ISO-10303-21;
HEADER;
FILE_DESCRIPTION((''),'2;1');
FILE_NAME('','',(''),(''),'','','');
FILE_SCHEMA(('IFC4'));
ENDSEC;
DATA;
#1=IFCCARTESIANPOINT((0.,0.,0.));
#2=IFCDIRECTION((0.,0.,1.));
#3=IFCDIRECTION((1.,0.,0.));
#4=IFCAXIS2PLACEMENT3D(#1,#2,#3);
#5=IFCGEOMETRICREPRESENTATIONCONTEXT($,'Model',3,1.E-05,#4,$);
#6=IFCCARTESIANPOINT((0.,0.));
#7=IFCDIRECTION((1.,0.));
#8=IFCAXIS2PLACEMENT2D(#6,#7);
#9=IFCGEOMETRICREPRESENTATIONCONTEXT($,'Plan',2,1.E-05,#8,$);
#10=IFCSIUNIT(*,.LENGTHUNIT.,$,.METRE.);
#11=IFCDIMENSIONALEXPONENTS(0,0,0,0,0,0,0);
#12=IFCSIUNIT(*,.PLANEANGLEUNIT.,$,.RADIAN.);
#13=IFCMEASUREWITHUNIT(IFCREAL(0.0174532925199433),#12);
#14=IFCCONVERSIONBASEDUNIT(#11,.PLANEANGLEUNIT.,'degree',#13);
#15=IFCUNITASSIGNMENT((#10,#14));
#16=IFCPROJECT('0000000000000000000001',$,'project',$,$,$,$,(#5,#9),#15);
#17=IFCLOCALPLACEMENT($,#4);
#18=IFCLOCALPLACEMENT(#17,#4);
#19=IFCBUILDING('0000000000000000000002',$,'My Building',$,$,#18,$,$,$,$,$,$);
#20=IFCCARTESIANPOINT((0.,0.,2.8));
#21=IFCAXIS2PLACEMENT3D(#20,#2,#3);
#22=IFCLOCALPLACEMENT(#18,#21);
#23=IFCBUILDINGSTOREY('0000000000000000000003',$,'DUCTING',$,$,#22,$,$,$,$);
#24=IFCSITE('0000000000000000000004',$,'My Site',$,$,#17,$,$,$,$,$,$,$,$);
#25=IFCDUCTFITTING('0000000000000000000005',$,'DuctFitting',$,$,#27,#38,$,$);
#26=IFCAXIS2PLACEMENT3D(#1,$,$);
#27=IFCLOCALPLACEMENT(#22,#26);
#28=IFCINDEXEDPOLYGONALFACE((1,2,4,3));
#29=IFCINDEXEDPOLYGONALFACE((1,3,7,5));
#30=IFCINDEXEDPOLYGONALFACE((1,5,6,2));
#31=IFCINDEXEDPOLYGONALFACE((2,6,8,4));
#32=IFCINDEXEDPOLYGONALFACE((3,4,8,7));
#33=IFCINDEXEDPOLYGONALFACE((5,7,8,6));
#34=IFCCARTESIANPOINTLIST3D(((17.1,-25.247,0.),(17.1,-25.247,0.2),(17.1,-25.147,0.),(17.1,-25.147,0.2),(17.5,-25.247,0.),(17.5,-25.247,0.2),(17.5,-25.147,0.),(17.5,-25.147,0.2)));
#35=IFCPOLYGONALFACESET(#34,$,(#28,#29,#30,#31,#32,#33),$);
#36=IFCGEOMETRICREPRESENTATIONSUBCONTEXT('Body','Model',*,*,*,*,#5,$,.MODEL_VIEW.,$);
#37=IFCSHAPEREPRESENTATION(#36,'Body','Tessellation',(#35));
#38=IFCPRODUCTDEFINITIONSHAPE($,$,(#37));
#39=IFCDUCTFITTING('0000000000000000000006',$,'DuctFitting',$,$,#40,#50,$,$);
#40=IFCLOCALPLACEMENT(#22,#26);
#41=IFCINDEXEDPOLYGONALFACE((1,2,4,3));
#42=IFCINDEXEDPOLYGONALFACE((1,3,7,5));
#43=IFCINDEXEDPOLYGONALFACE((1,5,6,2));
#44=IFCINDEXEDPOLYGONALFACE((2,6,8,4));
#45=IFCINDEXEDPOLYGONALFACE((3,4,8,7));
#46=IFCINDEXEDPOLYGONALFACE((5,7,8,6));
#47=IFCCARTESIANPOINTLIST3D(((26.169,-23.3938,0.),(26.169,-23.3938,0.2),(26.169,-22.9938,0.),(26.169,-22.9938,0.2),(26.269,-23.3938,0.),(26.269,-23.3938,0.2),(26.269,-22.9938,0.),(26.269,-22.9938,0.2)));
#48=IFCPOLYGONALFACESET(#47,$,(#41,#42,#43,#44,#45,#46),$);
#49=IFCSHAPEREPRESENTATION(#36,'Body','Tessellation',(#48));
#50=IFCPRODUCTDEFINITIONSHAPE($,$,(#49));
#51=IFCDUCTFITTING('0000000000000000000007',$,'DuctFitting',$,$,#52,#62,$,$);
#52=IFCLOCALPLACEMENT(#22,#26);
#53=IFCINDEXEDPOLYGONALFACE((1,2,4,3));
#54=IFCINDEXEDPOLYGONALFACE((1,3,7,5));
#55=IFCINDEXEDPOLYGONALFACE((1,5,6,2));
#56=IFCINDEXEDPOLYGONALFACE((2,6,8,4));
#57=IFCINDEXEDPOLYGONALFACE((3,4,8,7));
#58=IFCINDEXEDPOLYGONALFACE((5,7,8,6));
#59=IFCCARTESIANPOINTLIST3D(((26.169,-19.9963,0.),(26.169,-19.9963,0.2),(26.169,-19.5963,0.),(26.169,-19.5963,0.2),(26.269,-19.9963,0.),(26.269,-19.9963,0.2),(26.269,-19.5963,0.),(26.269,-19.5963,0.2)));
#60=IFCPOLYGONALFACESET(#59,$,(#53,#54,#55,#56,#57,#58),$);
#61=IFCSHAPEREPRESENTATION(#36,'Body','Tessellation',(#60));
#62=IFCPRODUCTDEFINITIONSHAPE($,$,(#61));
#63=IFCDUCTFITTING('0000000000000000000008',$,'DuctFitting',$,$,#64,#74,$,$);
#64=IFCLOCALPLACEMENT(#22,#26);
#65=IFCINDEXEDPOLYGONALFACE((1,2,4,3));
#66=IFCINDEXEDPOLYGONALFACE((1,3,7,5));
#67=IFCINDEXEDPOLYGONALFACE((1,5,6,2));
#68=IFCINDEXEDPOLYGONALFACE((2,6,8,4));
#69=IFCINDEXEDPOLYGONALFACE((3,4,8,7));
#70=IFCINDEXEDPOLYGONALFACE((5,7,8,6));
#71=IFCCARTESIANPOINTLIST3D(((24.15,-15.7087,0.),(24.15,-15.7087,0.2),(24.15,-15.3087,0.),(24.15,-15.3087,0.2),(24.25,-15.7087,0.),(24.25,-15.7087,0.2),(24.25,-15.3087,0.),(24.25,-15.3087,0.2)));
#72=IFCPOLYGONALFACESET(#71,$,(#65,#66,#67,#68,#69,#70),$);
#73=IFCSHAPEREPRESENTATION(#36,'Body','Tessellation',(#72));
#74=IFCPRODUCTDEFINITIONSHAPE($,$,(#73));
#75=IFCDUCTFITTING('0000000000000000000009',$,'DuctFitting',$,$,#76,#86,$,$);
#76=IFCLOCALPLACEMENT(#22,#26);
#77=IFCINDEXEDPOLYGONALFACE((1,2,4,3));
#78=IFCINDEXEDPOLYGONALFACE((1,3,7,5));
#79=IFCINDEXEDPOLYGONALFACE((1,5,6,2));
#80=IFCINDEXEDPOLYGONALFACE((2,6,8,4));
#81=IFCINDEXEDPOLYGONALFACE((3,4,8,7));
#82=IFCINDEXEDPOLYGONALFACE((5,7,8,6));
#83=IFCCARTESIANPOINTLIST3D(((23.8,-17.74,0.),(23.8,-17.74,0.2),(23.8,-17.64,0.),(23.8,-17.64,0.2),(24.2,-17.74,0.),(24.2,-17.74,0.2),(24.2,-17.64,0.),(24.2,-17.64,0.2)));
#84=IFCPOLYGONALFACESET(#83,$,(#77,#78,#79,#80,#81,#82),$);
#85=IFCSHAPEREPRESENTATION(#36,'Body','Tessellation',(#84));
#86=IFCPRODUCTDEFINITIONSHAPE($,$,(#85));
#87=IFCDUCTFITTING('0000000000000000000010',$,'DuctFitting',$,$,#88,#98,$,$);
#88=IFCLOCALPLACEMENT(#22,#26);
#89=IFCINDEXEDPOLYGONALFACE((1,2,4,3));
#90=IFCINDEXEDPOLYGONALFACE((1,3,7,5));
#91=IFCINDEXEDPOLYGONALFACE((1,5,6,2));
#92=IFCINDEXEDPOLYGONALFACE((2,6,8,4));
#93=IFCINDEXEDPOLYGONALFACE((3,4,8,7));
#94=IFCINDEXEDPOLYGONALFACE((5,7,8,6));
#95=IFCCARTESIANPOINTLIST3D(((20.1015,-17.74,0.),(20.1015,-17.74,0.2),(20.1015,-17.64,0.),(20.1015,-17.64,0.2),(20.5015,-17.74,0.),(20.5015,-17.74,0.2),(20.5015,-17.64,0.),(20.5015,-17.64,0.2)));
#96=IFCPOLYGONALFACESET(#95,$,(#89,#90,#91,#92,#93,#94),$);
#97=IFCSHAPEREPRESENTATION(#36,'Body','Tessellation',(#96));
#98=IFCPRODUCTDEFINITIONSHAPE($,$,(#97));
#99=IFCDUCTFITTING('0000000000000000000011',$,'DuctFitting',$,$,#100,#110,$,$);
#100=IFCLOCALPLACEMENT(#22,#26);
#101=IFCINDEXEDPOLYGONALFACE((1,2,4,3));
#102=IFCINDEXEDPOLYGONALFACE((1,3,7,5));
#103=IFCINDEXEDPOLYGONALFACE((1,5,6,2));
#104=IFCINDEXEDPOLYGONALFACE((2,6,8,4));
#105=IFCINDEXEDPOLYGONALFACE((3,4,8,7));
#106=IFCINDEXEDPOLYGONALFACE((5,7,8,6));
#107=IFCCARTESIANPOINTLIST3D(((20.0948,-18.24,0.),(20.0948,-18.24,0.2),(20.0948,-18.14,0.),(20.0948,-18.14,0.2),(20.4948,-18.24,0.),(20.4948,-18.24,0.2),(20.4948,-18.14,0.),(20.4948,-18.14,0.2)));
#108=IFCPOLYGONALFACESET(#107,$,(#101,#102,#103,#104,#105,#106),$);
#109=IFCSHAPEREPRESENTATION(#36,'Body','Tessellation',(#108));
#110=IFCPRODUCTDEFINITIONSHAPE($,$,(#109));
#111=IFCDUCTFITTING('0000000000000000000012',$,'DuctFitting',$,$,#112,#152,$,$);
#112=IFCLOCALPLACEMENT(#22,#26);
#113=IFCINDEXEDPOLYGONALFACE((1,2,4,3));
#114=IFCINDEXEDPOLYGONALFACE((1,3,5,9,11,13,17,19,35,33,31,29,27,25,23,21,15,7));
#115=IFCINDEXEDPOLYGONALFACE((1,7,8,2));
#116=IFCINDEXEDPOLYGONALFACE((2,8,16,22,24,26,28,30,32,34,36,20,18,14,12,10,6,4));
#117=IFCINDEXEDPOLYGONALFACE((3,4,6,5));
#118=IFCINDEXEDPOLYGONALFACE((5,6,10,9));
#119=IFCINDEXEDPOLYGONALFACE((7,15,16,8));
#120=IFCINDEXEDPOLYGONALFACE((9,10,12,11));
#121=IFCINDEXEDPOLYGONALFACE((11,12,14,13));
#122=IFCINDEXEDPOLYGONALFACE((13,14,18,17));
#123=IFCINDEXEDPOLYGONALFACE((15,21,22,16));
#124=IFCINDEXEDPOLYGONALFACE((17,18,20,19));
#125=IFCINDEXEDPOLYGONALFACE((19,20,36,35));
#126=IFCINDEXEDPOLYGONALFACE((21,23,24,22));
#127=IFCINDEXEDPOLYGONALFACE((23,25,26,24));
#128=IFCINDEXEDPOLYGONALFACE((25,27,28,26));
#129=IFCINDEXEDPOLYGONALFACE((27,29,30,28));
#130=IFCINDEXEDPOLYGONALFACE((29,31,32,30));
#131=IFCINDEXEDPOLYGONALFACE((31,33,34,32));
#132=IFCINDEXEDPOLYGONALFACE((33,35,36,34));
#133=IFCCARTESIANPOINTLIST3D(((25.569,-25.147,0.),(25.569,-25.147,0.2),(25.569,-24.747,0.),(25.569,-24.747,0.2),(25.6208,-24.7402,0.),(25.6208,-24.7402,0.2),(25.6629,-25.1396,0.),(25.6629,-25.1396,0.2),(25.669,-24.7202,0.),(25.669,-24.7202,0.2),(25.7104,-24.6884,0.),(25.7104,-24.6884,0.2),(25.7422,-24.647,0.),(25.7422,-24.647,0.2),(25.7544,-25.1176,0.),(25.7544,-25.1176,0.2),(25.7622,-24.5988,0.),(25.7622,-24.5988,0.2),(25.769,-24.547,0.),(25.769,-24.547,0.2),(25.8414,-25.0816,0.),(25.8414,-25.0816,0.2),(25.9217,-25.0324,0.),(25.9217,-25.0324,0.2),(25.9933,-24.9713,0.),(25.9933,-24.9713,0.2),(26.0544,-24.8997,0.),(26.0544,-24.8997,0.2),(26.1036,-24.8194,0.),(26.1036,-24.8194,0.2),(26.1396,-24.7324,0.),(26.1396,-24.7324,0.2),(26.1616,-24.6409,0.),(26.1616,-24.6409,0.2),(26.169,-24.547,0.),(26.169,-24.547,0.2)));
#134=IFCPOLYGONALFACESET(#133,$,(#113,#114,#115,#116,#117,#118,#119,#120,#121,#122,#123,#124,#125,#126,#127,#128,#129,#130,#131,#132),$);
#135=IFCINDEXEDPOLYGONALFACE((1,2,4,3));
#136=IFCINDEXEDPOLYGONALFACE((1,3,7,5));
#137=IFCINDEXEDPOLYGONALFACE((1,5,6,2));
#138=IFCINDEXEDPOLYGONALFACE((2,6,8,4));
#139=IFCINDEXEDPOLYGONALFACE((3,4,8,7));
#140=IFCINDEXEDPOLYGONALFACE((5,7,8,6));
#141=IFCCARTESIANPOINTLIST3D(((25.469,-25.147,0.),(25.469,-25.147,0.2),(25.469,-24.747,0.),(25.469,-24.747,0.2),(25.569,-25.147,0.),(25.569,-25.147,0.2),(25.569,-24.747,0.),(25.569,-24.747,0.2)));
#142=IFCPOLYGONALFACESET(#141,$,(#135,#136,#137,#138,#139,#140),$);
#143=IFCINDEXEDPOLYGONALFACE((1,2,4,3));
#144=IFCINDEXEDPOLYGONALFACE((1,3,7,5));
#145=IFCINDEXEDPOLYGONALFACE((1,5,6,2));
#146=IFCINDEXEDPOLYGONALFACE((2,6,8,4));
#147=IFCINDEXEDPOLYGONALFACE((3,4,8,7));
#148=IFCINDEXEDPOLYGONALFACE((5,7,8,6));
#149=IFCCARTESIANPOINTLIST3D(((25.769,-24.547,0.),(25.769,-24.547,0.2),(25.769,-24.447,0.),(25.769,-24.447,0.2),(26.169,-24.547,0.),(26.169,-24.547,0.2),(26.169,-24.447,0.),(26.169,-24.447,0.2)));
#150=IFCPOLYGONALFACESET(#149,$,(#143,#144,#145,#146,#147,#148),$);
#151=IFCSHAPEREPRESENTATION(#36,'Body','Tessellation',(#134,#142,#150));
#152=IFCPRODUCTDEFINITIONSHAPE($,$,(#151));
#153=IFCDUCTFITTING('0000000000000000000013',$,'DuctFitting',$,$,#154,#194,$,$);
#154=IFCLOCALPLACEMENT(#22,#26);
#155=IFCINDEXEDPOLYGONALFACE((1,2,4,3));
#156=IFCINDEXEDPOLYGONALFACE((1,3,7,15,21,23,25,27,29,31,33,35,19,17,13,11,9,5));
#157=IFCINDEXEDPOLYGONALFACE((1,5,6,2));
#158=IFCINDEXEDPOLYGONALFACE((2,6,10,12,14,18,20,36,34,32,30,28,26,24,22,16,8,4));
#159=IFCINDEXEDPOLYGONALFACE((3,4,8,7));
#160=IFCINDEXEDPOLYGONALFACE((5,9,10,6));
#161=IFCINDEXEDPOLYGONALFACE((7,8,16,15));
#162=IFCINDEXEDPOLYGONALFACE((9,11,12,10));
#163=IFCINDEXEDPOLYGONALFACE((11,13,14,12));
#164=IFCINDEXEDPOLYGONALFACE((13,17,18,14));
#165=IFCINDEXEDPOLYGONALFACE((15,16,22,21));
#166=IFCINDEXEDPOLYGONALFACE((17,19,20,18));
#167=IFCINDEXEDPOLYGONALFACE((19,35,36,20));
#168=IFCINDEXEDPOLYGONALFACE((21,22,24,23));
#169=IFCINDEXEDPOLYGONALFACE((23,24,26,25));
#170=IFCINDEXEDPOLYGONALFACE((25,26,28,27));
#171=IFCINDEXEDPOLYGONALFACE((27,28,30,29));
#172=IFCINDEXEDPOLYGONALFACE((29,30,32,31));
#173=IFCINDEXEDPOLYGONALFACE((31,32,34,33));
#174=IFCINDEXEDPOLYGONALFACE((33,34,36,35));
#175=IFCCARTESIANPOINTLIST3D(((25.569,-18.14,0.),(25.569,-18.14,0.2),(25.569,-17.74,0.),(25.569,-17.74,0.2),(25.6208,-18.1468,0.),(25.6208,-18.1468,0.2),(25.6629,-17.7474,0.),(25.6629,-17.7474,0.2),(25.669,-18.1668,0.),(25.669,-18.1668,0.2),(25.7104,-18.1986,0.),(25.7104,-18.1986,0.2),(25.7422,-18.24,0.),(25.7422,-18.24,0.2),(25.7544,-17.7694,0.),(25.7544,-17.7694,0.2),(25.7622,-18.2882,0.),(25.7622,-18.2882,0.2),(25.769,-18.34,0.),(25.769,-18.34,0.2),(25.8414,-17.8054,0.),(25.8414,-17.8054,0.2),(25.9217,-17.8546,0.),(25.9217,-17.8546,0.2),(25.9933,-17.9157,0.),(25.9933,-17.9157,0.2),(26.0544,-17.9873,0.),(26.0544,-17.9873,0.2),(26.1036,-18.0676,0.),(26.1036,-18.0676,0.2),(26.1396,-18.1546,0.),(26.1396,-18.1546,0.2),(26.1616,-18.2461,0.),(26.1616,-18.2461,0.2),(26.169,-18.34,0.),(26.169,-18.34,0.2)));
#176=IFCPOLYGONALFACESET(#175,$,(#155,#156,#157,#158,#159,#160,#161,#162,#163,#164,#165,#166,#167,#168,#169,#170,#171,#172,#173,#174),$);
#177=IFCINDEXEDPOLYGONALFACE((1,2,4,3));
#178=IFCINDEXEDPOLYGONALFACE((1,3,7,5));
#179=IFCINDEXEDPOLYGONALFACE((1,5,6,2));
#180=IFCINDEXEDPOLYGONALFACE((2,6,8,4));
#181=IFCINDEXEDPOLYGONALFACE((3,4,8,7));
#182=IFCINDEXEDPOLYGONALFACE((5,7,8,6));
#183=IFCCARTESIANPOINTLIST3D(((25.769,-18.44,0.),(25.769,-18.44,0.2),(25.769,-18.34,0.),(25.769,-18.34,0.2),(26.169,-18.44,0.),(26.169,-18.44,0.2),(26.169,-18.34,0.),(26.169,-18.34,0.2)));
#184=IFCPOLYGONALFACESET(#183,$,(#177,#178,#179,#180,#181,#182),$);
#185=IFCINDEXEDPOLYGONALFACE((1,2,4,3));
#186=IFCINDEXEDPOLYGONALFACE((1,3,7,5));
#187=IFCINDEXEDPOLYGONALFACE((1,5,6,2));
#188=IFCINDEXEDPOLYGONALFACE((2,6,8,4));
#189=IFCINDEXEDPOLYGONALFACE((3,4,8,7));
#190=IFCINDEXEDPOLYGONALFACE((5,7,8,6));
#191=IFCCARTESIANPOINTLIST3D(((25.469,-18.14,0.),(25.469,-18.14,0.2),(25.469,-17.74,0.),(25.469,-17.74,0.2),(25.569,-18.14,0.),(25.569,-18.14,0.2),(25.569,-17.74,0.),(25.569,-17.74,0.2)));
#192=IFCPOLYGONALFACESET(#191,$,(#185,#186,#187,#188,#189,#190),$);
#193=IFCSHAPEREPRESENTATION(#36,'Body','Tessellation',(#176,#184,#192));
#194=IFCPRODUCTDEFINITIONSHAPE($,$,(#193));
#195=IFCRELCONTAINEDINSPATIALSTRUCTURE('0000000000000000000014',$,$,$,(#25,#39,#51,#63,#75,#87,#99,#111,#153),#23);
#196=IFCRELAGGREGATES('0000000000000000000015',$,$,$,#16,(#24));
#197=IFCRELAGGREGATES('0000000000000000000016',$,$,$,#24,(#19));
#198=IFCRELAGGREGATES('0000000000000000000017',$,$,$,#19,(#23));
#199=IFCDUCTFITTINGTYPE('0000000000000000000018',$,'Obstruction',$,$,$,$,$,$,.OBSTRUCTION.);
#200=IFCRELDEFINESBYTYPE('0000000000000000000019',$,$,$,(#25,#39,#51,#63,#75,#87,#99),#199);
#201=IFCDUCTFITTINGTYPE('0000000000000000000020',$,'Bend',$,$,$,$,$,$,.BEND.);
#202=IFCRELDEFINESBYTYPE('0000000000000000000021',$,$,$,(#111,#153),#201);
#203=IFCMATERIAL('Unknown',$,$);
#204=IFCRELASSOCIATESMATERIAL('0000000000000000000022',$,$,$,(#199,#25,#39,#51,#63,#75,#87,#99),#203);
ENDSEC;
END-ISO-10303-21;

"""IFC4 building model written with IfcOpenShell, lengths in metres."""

from ifc_helpers import new_model, entity, si_unit, converted_unit, frame, origin_with_axes, origin_2d_with_axis, place, context, subcontext, project, spatial, line, arc, indexed_curve, rectangle, outline, extrude, source, transform, mapped, material, material_profile, profile_set, profile_usage, type_object, type_shapes, element, save


model = new_model("IFC4")

# Units and contexts
model_context = context("Model", 3, precision=1e-05, world=origin_with_axes())
plan_context = context("Plan", 2, precision=1e-05, world=origin_2d_with_axis())
body_context = subcontext(model_context, "Body", "Model", "MODEL_VIEW")
ifc_project = project(units=[si_unit("LENGTHUNIT", "METRE"), converted_unit("PLANEANGLEUNIT", "degree", entity("IfcReal", 0.0174532925199433), si_unit("PLANEANGLEUNIT", "RADIAN"), dimensions=[0, 0, 0, 0, 0, 0, 0])], contexts=[model_context, plan_context])

# Site, building, storey
site_placement = place(None, origin_with_axes())
site = spatial("IfcSite", under=ifc_project, at=site_placement, Name="My Site")
building_placement = place(site_placement, origin_with_axes())
building = spatial("IfcBuilding", under=site, at=building_placement, Name="My Building")
storey_placement = place(building_placement, frame((0.0, 0.0, 2.8), z_axis=(0.0, 0.0, 1.0), x_axis=(1.0, 0.0, 0.0)))
storey = spatial("IfcBuildingStorey", under=building, at=storey_placement, Name="DUCTING")

# Shared definitions
ifc_material = material(Name="Unknown")

# Duct fittings
ifc_material_profile_1 = material_profile(ifc_material, rectangle(XDim=0.4, YDim=0.2))
ifc_profile_set_1 = profile_set([ifc_material_profile_1])
duct_fitting_type_1 = type_object("IfcDuctFittingType", Name="Obstruction", PredefinedType="OBSTRUCTION", material=ifc_profile_set_1)
ifc_profile_usage_1 = profile_usage(ifc_profile_set_1, cardinal=5)
duct_fitting_1_placement = place(storey_placement, frame((17.3, -25.147, 0.1), z_axis=(0.0, -1.0, -0.000004), x_axis=(1.0, 0.0, 0.0)))
element("IfcDuctFitting", 1, at=duct_fitting_1_placement, inside=storey, type_object=duct_fitting_type_1, material=ifc_profile_usage_1, Name="DuctFitting", context=body_context, shape_type="SweptSolid", body=[
    extrude(rectangle(XDim=0.4, YDim=0.2), origin_with_axes(), (0.0, 0.0, 1.0), 0.1),
])
ifc_profile_usage_2 = profile_usage(ifc_profile_set_1, cardinal=5)
duct_fitting_2_placement = place(storey_placement, frame((26.269, -23.1938, 0.1), z_axis=(-1.0, 0.0, 0.0), x_axis=(0.0, -1.0, 0.0)))
element("IfcDuctFitting", 2, at=duct_fitting_2_placement, inside=storey, type_object=duct_fitting_type_1, material=ifc_profile_usage_2, Name="DuctFitting", context=body_context, shape_type="SweptSolid", body=[
    extrude(rectangle(XDim=0.4, YDim=0.2), origin_with_axes(), (0.0, 0.0, 1.0), 0.1),
])
ifc_profile_usage_3 = profile_usage(ifc_profile_set_1, cardinal=5)
duct_fitting_3_placement = place(storey_placement, frame((26.269, -19.7963, 0.1), z_axis=(-1.0, 0.0, 0.0), x_axis=(0.0, -1.0, 0.0)))
element("IfcDuctFitting", 3, at=duct_fitting_3_placement, inside=storey, type_object=duct_fitting_type_1, material=ifc_profile_usage_3, Name="DuctFitting", context=body_context, shape_type="SweptSolid", body=[
    extrude(rectangle(XDim=0.4, YDim=0.2), origin_with_axes(), (0.0, 0.0, 1.0), 0.1),
])
ifc_profile_usage_4 = profile_usage(ifc_profile_set_1, cardinal=5)
duct_fitting_4_placement = place(storey_placement, frame((24.15, -15.5087, 0.1), z_axis=(1.0, 0.0, -0.000004), x_axis=(0.0, 1.0, 0.0)))
element("IfcDuctFitting", 4, at=duct_fitting_4_placement, inside=storey, type_object=duct_fitting_type_1, material=ifc_profile_usage_4, Name="DuctFitting", context=body_context, shape_type="SweptSolid", body=[
    extrude(rectangle(XDim=0.4, YDim=0.2), origin_with_axes(), (0.0, 0.0, 1.0), 0.1),
])
ifc_profile_usage_5 = profile_usage(ifc_profile_set_1, cardinal=5)
duct_fitting_5_placement = place(storey_placement, frame((24.0, -17.74, 0.1), z_axis=(0.0, 1.0, -0.000004), x_axis=(-1.0, 0.0, 0.0)))
element("IfcDuctFitting", 5, at=duct_fitting_5_placement, inside=storey, type_object=duct_fitting_type_1, material=ifc_profile_usage_5, Name="DuctFitting", context=body_context, shape_type="SweptSolid", body=[
    extrude(rectangle(XDim=0.4, YDim=0.2), origin_with_axes(), (0.0, 0.0, 1.0), 0.1),
])
ifc_profile_usage_6 = profile_usage(ifc_profile_set_1, cardinal=5)
duct_fitting_6_placement = place(storey_placement, frame((20.3015, -17.74, 0.1), z_axis=(0.0, 1.0, -0.000004), x_axis=(-1.0, 0.0, 0.0)))
element("IfcDuctFitting", 6, at=duct_fitting_6_placement, inside=storey, type_object=duct_fitting_type_1, material=ifc_profile_usage_6, Name="DuctFitting", context=body_context, shape_type="SweptSolid", body=[
    extrude(rectangle(XDim=0.4, YDim=0.2), origin_with_axes(), (0.0, 0.0, 1.0), 0.1),
])
ifc_profile_usage_7 = profile_usage(ifc_profile_set_1, cardinal=5)
duct_fitting_7_placement = place(storey_placement, frame((20.2948, -18.14, 0.1), z_axis=(0.0, -1.0, -0.000004), x_axis=(1.0, 0.0, 0.0)))
element("IfcDuctFitting", 7, at=duct_fitting_7_placement, inside=storey, type_object=duct_fitting_type_1, material=ifc_profile_usage_7, Name="DuctFitting", context=body_context, shape_type="SweptSolid", body=[
    extrude(rectangle(XDim=0.4, YDim=0.2), origin_with_axes(), (0.0, 0.0, 1.0), 0.1),
])
duct_fitting_type_2 = type_object("IfcDuctFittingType", Name="Bend", PredefinedType="BEND")
shared_shape = source(origin_with_axes(), body_context, "Body", "SweptSolid", [
    extrude(outline(indexed_curve([(0.2, 0.0), (0.2586, 0.1414), (0.4, 0.2), (0.4, 0.6), (-0.0243, 0.4243), (-0.2, 0.0)], segments=[arc(1, 2, 3), line(3, 4), arc(4, 5, 6), line(6, 1)])), frame((0.0, -0.1, 0.1), z_axis=(0.0, -1.0, 0.0), x_axis=(1.0, 0.0, 0.0)), (0.0, 0.0, -1.0), 0.2),
    extrude(rectangle(XDim=0.4, YDim=0.2), origin_with_axes(), (0.0, 0.0, 1.0), 0.1),
    extrude(rectangle(XDim=0.4, YDim=0.2), frame((0.4, 0.0, 0.5), z_axis=(1.0, 0.0, 0.0), x_axis=(0.0, 0.0, 1.0)), (0.0, 0.0, 1.0), 0.1),
])
type_shapes(duct_fitting_type_2, [shared_shape])
for number, where, z_axis, x_axis, name in (
    (8, (25.469, -24.947, 0.1), (1.0, 0.0, 0.0), (0.0, 1.0, 0.0), "DuctFitting"),
    (9, (25.969, -18.44, 0.1), (0.0, 1.0, 0.0), (-1.0, 0.0, 0.0), "DuctFitting"),
):
    element("IfcDuctFitting", number, at=place(storey_placement, frame(where, z_axis=z_axis, x_axis=x_axis)), inside=storey, type_object=duct_fitting_type_2, Name=name, context=body_context, shape_type="MappedRepresentation", body=[
        mapped(shared_shape, transform((0.0, 0.0, 0.0), x_axis=(1.0, 0.0, 0.0), y_axis=(0.0, 1.0, 0.0), z_axis=(0.0, 0.0, 1.0), scale=1.0)),
    ])

save(model, "model.ifc")
